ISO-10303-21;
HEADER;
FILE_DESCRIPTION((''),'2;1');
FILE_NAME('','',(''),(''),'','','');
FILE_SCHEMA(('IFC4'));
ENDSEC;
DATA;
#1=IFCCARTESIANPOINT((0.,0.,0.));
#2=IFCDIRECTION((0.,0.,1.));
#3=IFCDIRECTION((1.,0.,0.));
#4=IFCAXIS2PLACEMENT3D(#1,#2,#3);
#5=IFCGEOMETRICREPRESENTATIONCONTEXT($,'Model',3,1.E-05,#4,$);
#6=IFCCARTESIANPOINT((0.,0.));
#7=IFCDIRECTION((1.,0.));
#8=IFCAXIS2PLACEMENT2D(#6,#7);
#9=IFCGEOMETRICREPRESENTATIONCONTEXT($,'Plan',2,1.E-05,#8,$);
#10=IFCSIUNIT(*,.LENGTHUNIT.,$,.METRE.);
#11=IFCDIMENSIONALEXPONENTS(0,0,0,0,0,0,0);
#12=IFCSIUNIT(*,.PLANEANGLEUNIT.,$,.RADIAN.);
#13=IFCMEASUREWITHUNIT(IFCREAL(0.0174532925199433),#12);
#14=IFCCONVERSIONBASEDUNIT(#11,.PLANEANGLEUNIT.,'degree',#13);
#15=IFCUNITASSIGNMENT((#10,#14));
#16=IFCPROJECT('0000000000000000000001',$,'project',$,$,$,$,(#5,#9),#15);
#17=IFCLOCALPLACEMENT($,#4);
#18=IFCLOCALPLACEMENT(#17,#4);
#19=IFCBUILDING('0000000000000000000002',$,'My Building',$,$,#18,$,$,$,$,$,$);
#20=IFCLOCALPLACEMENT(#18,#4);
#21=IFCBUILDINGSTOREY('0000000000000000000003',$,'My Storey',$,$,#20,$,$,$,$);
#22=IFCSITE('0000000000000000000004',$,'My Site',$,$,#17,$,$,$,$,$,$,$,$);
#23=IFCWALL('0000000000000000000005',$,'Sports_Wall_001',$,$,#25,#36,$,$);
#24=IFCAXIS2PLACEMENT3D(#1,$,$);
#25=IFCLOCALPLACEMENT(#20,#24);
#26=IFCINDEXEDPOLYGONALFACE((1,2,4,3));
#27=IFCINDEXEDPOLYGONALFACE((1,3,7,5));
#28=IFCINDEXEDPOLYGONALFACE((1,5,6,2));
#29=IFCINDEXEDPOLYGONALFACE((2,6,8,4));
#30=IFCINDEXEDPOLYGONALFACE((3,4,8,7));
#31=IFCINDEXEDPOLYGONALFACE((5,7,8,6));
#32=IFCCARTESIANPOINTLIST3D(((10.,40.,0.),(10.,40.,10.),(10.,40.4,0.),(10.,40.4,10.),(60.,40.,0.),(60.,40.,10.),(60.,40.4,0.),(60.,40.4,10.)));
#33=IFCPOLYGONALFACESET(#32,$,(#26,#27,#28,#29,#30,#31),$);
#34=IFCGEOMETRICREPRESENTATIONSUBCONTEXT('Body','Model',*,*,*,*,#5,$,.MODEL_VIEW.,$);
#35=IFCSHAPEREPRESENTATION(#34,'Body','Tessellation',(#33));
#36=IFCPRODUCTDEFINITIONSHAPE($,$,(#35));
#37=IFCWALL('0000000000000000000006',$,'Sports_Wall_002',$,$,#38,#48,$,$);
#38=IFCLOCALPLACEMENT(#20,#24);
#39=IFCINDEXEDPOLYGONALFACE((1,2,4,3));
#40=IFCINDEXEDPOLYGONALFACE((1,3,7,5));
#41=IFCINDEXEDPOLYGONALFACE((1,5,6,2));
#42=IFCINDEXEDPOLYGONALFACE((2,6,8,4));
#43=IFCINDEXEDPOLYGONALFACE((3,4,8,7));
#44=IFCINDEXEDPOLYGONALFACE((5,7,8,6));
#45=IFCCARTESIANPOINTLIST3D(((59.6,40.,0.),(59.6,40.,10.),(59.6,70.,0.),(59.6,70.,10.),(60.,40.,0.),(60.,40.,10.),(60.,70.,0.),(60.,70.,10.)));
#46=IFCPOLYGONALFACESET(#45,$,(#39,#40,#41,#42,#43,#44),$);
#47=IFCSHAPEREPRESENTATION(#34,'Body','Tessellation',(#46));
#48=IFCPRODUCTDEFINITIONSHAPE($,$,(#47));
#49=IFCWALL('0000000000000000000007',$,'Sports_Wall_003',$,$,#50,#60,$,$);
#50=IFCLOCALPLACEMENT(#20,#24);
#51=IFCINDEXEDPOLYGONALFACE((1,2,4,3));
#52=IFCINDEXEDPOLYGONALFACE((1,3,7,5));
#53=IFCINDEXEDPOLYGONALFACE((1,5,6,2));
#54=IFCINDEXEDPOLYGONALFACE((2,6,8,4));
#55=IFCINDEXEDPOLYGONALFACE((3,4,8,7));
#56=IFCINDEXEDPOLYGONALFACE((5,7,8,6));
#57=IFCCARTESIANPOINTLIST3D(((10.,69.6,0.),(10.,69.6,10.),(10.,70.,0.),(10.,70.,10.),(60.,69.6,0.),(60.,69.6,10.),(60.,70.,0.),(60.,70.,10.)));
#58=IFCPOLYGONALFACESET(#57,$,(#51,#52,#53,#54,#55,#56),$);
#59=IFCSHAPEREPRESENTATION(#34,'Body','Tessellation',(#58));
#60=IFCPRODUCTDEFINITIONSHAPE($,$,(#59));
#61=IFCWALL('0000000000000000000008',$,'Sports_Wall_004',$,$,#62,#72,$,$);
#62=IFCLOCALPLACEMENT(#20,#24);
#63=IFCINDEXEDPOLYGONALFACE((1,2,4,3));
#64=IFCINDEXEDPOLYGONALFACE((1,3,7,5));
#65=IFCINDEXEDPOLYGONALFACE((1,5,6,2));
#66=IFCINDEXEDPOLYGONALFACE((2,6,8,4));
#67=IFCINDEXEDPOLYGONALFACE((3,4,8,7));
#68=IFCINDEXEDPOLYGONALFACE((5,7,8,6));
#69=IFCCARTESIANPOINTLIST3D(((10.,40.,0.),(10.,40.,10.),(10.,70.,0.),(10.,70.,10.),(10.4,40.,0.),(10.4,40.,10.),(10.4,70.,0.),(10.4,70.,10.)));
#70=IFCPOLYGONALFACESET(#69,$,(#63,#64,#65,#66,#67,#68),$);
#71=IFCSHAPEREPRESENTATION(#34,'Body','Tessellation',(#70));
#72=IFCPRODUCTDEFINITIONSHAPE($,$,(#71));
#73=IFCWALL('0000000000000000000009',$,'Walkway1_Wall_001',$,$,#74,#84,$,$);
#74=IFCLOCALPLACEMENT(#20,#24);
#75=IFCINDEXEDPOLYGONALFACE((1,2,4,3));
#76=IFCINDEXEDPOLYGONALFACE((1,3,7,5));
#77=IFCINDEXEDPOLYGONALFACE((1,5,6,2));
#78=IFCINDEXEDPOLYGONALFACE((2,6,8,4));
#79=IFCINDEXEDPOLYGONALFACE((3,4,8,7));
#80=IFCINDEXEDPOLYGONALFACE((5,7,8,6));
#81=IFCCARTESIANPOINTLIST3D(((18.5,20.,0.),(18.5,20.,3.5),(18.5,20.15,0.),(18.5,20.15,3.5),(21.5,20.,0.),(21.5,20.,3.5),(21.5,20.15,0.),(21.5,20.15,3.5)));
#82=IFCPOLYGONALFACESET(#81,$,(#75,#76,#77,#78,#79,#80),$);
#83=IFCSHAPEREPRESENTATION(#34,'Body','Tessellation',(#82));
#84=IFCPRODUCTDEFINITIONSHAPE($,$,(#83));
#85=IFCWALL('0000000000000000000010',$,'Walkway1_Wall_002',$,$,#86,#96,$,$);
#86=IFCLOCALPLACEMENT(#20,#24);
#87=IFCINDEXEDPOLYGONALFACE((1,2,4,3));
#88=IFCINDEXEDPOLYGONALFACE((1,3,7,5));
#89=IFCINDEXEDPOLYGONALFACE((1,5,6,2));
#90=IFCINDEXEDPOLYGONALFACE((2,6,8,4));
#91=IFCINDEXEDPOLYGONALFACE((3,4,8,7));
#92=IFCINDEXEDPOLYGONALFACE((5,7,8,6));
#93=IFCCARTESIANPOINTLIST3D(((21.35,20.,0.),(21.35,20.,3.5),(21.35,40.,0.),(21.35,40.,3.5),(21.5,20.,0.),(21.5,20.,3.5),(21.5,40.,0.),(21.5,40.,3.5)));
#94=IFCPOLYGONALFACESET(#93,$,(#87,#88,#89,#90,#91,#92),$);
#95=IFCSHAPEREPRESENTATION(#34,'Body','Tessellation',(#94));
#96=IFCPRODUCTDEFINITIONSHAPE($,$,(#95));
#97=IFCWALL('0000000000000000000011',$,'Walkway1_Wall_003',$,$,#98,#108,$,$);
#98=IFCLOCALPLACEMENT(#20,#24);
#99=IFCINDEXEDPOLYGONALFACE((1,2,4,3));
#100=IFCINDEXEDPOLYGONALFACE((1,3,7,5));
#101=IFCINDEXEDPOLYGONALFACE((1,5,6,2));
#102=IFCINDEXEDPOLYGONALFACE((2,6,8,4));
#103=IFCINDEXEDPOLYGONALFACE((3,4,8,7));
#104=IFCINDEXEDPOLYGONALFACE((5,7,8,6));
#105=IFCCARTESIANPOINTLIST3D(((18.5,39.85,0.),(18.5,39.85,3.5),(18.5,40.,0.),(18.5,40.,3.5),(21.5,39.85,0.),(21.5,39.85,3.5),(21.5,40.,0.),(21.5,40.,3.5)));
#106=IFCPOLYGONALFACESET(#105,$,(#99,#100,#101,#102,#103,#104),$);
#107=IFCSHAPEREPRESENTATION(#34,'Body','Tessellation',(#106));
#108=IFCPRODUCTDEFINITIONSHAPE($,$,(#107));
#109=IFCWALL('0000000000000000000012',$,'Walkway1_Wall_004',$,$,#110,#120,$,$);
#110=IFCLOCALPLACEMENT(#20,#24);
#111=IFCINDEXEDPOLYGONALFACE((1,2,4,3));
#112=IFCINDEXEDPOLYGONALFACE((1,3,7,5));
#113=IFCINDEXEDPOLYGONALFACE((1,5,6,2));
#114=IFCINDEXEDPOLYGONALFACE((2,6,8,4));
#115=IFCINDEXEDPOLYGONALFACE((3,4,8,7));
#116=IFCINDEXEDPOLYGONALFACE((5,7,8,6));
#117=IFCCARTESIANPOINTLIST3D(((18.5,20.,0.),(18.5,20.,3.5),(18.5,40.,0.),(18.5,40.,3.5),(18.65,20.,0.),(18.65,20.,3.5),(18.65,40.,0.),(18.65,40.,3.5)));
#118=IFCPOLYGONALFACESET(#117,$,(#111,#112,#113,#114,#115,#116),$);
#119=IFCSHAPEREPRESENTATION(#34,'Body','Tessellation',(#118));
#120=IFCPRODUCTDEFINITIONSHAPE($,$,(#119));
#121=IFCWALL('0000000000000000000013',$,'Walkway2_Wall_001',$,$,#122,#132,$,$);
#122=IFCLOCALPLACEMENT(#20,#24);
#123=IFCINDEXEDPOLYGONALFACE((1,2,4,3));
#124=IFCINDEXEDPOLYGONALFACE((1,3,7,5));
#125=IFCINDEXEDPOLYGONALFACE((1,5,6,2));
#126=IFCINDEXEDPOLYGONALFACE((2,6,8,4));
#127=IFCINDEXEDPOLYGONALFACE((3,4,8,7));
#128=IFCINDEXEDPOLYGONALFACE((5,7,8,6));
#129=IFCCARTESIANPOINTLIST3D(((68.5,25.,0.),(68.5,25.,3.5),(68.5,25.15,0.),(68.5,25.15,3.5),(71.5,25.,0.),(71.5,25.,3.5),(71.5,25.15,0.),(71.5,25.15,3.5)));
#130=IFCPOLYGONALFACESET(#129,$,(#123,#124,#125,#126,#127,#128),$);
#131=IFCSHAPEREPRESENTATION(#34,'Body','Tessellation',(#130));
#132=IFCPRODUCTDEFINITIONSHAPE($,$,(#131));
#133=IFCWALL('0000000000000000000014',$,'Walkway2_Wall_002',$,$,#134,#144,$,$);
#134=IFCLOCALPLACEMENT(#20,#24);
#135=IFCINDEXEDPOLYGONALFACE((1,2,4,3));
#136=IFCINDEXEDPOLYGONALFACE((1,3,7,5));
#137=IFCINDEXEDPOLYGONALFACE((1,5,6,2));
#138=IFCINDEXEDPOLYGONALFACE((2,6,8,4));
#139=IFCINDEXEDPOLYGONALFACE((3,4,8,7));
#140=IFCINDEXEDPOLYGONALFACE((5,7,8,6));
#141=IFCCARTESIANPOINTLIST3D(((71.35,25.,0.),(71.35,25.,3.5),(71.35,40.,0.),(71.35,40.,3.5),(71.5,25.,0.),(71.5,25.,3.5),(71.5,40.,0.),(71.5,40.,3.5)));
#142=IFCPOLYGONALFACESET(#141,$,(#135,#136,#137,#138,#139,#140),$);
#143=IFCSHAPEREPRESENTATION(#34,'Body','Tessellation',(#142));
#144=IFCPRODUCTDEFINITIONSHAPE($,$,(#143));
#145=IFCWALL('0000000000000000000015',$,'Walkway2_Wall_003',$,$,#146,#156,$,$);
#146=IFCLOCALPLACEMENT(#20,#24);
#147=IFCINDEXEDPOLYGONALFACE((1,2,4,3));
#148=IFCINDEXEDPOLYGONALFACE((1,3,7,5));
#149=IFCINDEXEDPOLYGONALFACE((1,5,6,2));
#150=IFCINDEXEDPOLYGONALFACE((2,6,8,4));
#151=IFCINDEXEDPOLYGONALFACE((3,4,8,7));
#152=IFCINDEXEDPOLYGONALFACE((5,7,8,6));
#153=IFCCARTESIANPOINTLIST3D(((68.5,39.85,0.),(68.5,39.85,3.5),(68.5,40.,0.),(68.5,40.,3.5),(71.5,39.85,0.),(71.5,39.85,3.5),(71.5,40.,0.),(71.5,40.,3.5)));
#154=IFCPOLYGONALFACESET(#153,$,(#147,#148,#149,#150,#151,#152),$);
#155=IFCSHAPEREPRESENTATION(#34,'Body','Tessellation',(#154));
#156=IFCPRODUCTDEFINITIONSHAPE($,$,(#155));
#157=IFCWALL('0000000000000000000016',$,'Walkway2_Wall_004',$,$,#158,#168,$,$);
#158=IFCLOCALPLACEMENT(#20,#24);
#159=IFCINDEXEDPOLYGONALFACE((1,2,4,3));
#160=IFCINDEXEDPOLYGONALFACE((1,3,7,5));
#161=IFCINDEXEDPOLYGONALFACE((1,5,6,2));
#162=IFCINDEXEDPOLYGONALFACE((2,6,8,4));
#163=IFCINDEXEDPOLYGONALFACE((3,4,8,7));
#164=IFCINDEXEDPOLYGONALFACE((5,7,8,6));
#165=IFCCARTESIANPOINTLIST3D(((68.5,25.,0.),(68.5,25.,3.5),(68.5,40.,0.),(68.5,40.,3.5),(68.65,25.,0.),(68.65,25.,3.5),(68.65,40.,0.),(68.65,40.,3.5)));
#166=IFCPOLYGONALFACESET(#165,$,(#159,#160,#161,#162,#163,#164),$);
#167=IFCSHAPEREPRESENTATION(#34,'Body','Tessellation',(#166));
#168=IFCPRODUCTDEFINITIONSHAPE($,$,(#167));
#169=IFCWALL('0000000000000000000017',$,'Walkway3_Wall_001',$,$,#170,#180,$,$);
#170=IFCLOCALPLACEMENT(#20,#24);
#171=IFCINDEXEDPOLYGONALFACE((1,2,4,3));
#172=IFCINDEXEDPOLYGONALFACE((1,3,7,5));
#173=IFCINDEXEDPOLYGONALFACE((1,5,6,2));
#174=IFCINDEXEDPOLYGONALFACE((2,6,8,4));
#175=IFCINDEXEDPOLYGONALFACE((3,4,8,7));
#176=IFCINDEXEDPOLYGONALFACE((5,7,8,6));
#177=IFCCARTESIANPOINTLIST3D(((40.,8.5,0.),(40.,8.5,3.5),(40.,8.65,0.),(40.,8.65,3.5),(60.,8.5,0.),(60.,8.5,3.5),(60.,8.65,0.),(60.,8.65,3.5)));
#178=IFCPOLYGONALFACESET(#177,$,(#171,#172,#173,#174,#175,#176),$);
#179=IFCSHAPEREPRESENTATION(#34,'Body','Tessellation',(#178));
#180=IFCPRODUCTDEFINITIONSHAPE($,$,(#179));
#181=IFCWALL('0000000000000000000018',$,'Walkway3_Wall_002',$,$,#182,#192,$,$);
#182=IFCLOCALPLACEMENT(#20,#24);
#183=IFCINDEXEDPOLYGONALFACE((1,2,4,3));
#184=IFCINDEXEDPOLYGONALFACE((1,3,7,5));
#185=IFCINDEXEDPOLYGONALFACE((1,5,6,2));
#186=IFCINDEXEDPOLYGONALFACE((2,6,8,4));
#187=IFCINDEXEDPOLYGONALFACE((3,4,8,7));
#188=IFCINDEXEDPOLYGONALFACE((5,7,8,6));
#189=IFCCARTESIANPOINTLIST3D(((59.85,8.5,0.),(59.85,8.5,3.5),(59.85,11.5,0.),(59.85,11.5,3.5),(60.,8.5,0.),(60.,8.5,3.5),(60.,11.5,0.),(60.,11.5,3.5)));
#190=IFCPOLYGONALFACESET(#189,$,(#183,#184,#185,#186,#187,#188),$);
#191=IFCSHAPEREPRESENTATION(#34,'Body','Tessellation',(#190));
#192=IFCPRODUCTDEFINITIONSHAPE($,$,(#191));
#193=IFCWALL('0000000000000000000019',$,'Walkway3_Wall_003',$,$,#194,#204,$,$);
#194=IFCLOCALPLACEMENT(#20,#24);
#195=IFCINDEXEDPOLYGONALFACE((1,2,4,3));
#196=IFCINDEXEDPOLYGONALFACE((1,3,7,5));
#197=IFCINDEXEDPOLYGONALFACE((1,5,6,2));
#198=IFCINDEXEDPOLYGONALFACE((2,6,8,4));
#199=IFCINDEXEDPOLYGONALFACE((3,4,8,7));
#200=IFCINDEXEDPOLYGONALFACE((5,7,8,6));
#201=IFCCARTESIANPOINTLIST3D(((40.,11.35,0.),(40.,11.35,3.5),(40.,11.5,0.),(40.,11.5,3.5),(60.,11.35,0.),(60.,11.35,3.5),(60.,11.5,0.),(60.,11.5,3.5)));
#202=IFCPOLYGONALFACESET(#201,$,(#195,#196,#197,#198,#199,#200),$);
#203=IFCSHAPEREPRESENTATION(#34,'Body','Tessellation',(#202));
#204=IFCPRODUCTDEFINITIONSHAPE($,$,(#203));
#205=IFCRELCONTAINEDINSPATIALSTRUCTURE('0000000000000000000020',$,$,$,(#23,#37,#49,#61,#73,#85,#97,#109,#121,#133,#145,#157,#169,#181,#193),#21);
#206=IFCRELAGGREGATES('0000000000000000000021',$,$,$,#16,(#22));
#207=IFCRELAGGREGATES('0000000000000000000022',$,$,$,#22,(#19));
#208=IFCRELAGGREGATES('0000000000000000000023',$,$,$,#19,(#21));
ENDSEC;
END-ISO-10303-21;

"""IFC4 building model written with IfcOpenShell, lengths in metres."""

from ifc_helpers import new_model, entity, si_unit, converted_unit, frame, origin_with_axes, origin_2d_with_axis, place, context, subcontext, project, spatial, indexed_curve, outline, extrude, element, save


model = new_model("IFC4")

# Units and contexts
model_context = context("Model", 3, precision=1e-05, world=origin_with_axes())
plan_context = context("Plan", 2, precision=1e-05, world=origin_2d_with_axis())
body_context = subcontext(model_context, "Body", "Model", "MODEL_VIEW")
ifc_project = project(units=[si_unit("LENGTHUNIT", "METRE"), converted_unit("PLANEANGLEUNIT", "degree", entity("IfcReal", 0.0174532925199433), si_unit("PLANEANGLEUNIT", "RADIAN"), dimensions=[0, 0, 0, 0, 0, 0, 0])], contexts=[model_context, plan_context])

# Site, building, storey
site_placement = place(None, origin_with_axes())
site = spatial("IfcSite", under=ifc_project, at=site_placement, Name="My Site")
building_placement = place(site_placement, origin_with_axes())
building = spatial("IfcBuilding", under=site, at=building_placement, Name="My Building")
storey_placement = place(building_placement, origin_with_axes())
storey = spatial("IfcBuildingStorey", under=building, at=storey_placement, Name="My Storey")

# Walls
wall_1_placement = place(storey_placement, frame((10.0, 40.0, 0.0), z_axis=(0.0, 0.0, 1.0), x_axis=(1.0, 0.0, 0.0)))
element("IfcWall", 1, at=wall_1_placement, inside=storey, Name="Sports_Wall_001", context=body_context, shape_type="SweptSolid", body=[
    extrude(outline(indexed_curve([(0.0, 0.0), (0.0, 0.4), (50.0, 0.4), (50.0, 0.0), (0.0, 0.0)], self_intersect=False)), origin_with_axes(), (0.0, 0.0, 1.0), 10.0),
])
wall_2_placement = place(storey_placement, frame((60.0, 40.0, 0.0), z_axis=(0.0, 0.0, 1.0), x_axis=(0.0, 1.0, 0.0)))
element("IfcWall", 2, at=wall_2_placement, inside=storey, Name="Sports_Wall_002", context=body_context, shape_type="SweptSolid", body=[
    extrude(outline(indexed_curve([(0.0, 0.0), (0.0, 0.4), (30.0, 0.4), (30.0, 0.0), (0.0, 0.0)], self_intersect=False)), origin_with_axes(), (0.0, 0.0, 1.0), 10.0),
])
wall_3_placement = place(storey_placement, frame((60.0, 70.0, 0.0), z_axis=(0.0, 0.0, 1.0), x_axis=(-1.0, 0.0, 0.0)))
element("IfcWall", 3, at=wall_3_placement, inside=storey, Name="Sports_Wall_003", context=body_context, shape_type="SweptSolid", body=[
    extrude(outline(indexed_curve([(0.0, 0.0), (0.0, 0.4), (50.0, 0.4), (50.0, 0.0), (0.0, 0.0)], self_intersect=False)), origin_with_axes(), (0.0, 0.0, 1.0), 10.0),
])
wall_4_placement = place(storey_placement, frame((10.0, 70.0, 0.0), z_axis=(0.0, 0.0, 1.0), x_axis=(0.0, -1.0, 0.0)))
element("IfcWall", 4, at=wall_4_placement, inside=storey, Name="Sports_Wall_004", context=body_context, shape_type="SweptSolid", body=[
    extrude(outline(indexed_curve([(0.0, 0.0), (0.0, 0.4), (30.0, 0.4), (30.0, 0.0), (0.0, 0.0)], self_intersect=False)), origin_with_axes(), (0.0, 0.0, 1.0), 10.0),
])
wall_5_placement = place(storey_placement, frame((18.5, 20.0, 0.0), z_axis=(0.0, 0.0, 1.0), x_axis=(1.0, 0.0, 0.0)))
element("IfcWall", 5, at=wall_5_placement, inside=storey, Name="Walkway1_Wall_001", context=body_context, shape_type="SweptSolid", body=[
    extrude(outline(indexed_curve([(0.0, 0.0), (0.0, 0.15), (3.0, 0.15), (3.0, 0.0), (0.0, 0.0)], self_intersect=False)), origin_with_axes(), (0.0, 0.0, 1.0), 3.5),
])
wall_6_placement = place(storey_placement, frame((21.5, 20.0, 0.0), z_axis=(0.0, 0.0, 1.0), x_axis=(0.0, 1.0, 0.0)))
element("IfcWall", 6, at=wall_6_placement, inside=storey, Name="Walkway1_Wall_002", context=body_context, shape_type="SweptSolid", body=[
    extrude(outline(indexed_curve([(0.0, 0.0), (0.0, 0.15), (20.0, 0.15), (20.0, 0.0), (0.0, 0.0)], self_intersect=False)), origin_with_axes(), (0.0, 0.0, 1.0), 3.5),
])
wall_7_placement = place(storey_placement, frame((21.5, 40.0, 0.0), z_axis=(0.0, 0.0, 1.0), x_axis=(-1.0, 0.0, 0.0)))
element("IfcWall", 7, at=wall_7_placement, inside=storey, Name="Walkway1_Wall_003", context=body_context, shape_type="SweptSolid", body=[
    extrude(outline(indexed_curve([(0.0, 0.0), (0.0, 0.15), (3.0, 0.15), (3.0, 0.0), (0.0, 0.0)], self_intersect=False)), origin_with_axes(), (0.0, 0.0, 1.0), 3.5),
])
wall_8_placement = place(storey_placement, frame((18.5, 40.0, 0.0), z_axis=(0.0, 0.0, 1.0), x_axis=(0.0, -1.0, 0.0)))
element("IfcWall", 8, at=wall_8_placement, inside=storey, Name="Walkway1_Wall_004", context=body_context, shape_type="SweptSolid", body=[
    extrude(outline(indexed_curve([(0.0, 0.0), (0.0, 0.15), (20.0, 0.15), (20.0, 0.0), (0.0, 0.0)], self_intersect=False)), origin_with_axes(), (0.0, 0.0, 1.0), 3.5),
])
wall_9_placement = place(storey_placement, frame((68.5, 25.0, 0.0), z_axis=(0.0, 0.0, 1.0), x_axis=(1.0, 0.0, 0.0)))
element("IfcWall", 9, at=wall_9_placement, inside=storey, Name="Walkway2_Wall_001", context=body_context, shape_type="SweptSolid", body=[
    extrude(outline(indexed_curve([(0.0, 0.0), (0.0, 0.15), (3.0, 0.15), (3.0, 0.0), (0.0, 0.0)], self_intersect=False)), origin_with_axes(), (0.0, 0.0, 1.0), 3.5),
])
wall_10_placement = place(storey_placement, frame((71.5, 25.0, 0.0), z_axis=(0.0, 0.0, 1.0), x_axis=(0.0, 1.0, 0.0)))
element("IfcWall", 10, at=wall_10_placement, inside=storey, Name="Walkway2_Wall_002", context=body_context, shape_type="SweptSolid", body=[
    extrude(outline(indexed_curve([(0.0, 0.0), (0.0, 0.15), (15.0, 0.15), (15.0, 0.0), (0.0, 0.0)], self_intersect=False)), origin_with_axes(), (0.0, 0.0, 1.0), 3.5),
])
wall_11_placement = place(storey_placement, frame((71.5, 40.0, 0.0), z_axis=(0.0, 0.0, 1.0), x_axis=(-1.0, 0.0, 0.0)))
element("IfcWall", 11, at=wall_11_placement, inside=storey, Name="Walkway2_Wall_003", context=body_context, shape_type="SweptSolid", body=[
    extrude(outline(indexed_curve([(0.0, 0.0), (0.0, 0.15), (3.0, 0.15), (3.0, 0.0), (0.0, 0.0)], self_intersect=False)), origin_with_axes(), (0.0, 0.0, 1.0), 3.5),
])
wall_12_placement = place(storey_placement, frame((68.5, 40.0, 0.0), z_axis=(0.0, 0.0, 1.0), x_axis=(0.0, -1.0, 0.0)))
element("IfcWall", 12, at=wall_12_placement, inside=storey, Name="Walkway2_Wall_004", context=body_context, shape_type="SweptSolid", body=[
    extrude(outline(indexed_curve([(0.0, 0.0), (0.0, 0.15), (15.0, 0.15), (15.0, 0.0), (0.0, 0.0)], self_intersect=False)), origin_with_axes(), (0.0, 0.0, 1.0), 3.5),
])
wall_13_placement = place(storey_placement, frame((40.0, 8.5, 0.0), z_axis=(0.0, 0.0, 1.0), x_axis=(1.0, 0.0, 0.0)))
element("IfcWall", 13, at=wall_13_placement, inside=storey, Name="Walkway3_Wall_001", context=body_context, shape_type="SweptSolid", body=[
    extrude(outline(indexed_curve([(0.0, 0.0), (0.0, 0.15), (20.0, 0.15), (20.0, 0.0), (0.0, 0.0)], self_intersect=False)), origin_with_axes(), (0.0, 0.0, 1.0), 3.5),
])
wall_14_placement = place(storey_placement, frame((60.0, 8.5, 0.0), z_axis=(0.0, 0.0, 1.0), x_axis=(0.0, 1.0, 0.0)))
element("IfcWall", 14, at=wall_14_placement, inside=storey, Name="Walkway3_Wall_002", context=body_context, shape_type="SweptSolid", body=[
    extrude(outline(indexed_curve([(0.0, 0.0), (0.0, 0.15), (3.0, 0.15), (3.0, 0.0), (0.0, 0.0)], self_intersect=False)), origin_with_axes(), (0.0, 0.0, 1.0), 3.5),
])
wall_15_placement = place(storey_placement, frame((60.0, 11.5, 0.0), z_axis=(0.0, 0.0, 1.0), x_axis=(-1.0, 0.0, 0.0)))
element("IfcWall", 15, at=wall_15_placement, inside=storey, Name="Walkway3_Wall_003", context=body_context, shape_type="SweptSolid", body=[
    extrude(outline(indexed_curve([(0.0, 0.0), (0.0, 0.15), (20.0, 0.15), (20.0, 0.0), (0.0, 0.0)], self_intersect=False)), origin_with_axes(), (0.0, 0.0, 1.0), 3.5),
])

save(model, "model.ifc")
